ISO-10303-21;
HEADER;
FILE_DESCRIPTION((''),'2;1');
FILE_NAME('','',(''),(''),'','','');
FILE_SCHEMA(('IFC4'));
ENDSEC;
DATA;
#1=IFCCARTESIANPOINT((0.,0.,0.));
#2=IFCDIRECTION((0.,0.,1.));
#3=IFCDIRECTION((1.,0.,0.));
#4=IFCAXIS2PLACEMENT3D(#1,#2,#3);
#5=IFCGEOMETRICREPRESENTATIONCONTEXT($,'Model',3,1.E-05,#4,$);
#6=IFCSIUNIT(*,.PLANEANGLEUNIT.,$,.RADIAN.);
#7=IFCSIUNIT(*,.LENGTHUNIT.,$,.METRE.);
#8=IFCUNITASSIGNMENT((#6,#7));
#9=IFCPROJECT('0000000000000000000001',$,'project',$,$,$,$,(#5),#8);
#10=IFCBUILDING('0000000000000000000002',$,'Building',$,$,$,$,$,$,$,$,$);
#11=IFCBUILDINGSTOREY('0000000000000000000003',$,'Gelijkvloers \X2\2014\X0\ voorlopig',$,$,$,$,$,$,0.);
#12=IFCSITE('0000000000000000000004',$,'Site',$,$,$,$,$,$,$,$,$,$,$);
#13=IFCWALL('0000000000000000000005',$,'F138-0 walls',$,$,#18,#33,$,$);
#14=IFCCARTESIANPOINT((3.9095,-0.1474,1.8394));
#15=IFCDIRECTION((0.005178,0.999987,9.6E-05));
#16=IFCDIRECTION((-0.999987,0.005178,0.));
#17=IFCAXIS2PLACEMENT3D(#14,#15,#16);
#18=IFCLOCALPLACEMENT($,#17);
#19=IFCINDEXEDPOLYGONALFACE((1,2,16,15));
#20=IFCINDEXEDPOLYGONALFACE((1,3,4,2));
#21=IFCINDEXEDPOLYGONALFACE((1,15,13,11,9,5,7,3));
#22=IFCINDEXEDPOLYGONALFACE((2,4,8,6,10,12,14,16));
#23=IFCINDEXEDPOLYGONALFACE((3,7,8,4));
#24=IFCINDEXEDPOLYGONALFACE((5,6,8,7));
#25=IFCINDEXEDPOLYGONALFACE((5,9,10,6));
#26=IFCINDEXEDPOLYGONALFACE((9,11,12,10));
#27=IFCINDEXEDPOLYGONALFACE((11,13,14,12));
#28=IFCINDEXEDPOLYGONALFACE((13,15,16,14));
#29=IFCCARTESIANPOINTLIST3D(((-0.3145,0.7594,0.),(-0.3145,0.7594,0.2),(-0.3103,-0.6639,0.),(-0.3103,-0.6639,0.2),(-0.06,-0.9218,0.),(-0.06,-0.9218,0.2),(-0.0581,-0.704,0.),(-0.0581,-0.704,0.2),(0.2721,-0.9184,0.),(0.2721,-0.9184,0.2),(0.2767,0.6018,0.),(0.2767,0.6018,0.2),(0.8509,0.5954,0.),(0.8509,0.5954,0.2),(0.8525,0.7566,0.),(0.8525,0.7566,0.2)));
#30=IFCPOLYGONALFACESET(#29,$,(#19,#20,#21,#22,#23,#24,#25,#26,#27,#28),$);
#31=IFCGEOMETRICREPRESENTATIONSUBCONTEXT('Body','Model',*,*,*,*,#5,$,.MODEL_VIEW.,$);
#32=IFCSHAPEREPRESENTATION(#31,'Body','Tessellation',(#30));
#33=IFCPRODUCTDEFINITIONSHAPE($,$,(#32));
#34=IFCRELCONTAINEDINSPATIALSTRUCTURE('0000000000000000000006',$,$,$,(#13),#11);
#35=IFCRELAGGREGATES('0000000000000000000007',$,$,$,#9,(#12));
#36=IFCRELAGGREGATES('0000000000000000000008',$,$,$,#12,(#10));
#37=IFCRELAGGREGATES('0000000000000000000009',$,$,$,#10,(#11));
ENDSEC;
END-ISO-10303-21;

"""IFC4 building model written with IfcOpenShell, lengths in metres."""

from ifc_helpers import new_model, si_unit, frame, origin_with_axes, place, context, subcontext, project, spatial, polyline, outline, extrude, element, save


model = new_model("IFC4")

# Units and contexts
model_context = context("Model", 3, precision=1e-05, world=origin_with_axes())
body_context = subcontext(model_context, "Body", "Model", "MODEL_VIEW")
ifc_project = project(units=[si_unit("PLANEANGLEUNIT", "RADIAN"), si_unit("LENGTHUNIT", "METRE")], contexts=[model_context])

# Site, building, storey
site = spatial("IfcSite", under=ifc_project, Name="Site")
building = spatial("IfcBuilding", under=site, Name="Building")
storey = spatial("IfcBuildingStorey", under=building, Name="Gelijkvloers — voorlopig", Elevation=0.0)

# Wall
wall_1_placement = place(None, frame((3.9095, -0.1474, 1.8394), z_axis=(0.005178, 0.999987, 0.000096), x_axis=(-0.999987, 0.005178, 0.0)))
element("IfcWall", 1, at=wall_1_placement, inside=storey, Name="F138-0 walls", context=body_context, shape_type="SweptSolid", body=[
    extrude(outline(polyline([(-0.06, -0.9218), (0.2721, -0.9184), (0.2767, 0.6018), (0.8509, 0.5954), (0.8525, 0.7566), (-0.3145, 0.7594), (-0.3103, -0.6639), (-0.0581, -0.704), (-0.06, -0.9218)])), origin_with_axes(), (0.0, 0.0, 1.0), 0.2),
])

save(model, "model.ifc")
